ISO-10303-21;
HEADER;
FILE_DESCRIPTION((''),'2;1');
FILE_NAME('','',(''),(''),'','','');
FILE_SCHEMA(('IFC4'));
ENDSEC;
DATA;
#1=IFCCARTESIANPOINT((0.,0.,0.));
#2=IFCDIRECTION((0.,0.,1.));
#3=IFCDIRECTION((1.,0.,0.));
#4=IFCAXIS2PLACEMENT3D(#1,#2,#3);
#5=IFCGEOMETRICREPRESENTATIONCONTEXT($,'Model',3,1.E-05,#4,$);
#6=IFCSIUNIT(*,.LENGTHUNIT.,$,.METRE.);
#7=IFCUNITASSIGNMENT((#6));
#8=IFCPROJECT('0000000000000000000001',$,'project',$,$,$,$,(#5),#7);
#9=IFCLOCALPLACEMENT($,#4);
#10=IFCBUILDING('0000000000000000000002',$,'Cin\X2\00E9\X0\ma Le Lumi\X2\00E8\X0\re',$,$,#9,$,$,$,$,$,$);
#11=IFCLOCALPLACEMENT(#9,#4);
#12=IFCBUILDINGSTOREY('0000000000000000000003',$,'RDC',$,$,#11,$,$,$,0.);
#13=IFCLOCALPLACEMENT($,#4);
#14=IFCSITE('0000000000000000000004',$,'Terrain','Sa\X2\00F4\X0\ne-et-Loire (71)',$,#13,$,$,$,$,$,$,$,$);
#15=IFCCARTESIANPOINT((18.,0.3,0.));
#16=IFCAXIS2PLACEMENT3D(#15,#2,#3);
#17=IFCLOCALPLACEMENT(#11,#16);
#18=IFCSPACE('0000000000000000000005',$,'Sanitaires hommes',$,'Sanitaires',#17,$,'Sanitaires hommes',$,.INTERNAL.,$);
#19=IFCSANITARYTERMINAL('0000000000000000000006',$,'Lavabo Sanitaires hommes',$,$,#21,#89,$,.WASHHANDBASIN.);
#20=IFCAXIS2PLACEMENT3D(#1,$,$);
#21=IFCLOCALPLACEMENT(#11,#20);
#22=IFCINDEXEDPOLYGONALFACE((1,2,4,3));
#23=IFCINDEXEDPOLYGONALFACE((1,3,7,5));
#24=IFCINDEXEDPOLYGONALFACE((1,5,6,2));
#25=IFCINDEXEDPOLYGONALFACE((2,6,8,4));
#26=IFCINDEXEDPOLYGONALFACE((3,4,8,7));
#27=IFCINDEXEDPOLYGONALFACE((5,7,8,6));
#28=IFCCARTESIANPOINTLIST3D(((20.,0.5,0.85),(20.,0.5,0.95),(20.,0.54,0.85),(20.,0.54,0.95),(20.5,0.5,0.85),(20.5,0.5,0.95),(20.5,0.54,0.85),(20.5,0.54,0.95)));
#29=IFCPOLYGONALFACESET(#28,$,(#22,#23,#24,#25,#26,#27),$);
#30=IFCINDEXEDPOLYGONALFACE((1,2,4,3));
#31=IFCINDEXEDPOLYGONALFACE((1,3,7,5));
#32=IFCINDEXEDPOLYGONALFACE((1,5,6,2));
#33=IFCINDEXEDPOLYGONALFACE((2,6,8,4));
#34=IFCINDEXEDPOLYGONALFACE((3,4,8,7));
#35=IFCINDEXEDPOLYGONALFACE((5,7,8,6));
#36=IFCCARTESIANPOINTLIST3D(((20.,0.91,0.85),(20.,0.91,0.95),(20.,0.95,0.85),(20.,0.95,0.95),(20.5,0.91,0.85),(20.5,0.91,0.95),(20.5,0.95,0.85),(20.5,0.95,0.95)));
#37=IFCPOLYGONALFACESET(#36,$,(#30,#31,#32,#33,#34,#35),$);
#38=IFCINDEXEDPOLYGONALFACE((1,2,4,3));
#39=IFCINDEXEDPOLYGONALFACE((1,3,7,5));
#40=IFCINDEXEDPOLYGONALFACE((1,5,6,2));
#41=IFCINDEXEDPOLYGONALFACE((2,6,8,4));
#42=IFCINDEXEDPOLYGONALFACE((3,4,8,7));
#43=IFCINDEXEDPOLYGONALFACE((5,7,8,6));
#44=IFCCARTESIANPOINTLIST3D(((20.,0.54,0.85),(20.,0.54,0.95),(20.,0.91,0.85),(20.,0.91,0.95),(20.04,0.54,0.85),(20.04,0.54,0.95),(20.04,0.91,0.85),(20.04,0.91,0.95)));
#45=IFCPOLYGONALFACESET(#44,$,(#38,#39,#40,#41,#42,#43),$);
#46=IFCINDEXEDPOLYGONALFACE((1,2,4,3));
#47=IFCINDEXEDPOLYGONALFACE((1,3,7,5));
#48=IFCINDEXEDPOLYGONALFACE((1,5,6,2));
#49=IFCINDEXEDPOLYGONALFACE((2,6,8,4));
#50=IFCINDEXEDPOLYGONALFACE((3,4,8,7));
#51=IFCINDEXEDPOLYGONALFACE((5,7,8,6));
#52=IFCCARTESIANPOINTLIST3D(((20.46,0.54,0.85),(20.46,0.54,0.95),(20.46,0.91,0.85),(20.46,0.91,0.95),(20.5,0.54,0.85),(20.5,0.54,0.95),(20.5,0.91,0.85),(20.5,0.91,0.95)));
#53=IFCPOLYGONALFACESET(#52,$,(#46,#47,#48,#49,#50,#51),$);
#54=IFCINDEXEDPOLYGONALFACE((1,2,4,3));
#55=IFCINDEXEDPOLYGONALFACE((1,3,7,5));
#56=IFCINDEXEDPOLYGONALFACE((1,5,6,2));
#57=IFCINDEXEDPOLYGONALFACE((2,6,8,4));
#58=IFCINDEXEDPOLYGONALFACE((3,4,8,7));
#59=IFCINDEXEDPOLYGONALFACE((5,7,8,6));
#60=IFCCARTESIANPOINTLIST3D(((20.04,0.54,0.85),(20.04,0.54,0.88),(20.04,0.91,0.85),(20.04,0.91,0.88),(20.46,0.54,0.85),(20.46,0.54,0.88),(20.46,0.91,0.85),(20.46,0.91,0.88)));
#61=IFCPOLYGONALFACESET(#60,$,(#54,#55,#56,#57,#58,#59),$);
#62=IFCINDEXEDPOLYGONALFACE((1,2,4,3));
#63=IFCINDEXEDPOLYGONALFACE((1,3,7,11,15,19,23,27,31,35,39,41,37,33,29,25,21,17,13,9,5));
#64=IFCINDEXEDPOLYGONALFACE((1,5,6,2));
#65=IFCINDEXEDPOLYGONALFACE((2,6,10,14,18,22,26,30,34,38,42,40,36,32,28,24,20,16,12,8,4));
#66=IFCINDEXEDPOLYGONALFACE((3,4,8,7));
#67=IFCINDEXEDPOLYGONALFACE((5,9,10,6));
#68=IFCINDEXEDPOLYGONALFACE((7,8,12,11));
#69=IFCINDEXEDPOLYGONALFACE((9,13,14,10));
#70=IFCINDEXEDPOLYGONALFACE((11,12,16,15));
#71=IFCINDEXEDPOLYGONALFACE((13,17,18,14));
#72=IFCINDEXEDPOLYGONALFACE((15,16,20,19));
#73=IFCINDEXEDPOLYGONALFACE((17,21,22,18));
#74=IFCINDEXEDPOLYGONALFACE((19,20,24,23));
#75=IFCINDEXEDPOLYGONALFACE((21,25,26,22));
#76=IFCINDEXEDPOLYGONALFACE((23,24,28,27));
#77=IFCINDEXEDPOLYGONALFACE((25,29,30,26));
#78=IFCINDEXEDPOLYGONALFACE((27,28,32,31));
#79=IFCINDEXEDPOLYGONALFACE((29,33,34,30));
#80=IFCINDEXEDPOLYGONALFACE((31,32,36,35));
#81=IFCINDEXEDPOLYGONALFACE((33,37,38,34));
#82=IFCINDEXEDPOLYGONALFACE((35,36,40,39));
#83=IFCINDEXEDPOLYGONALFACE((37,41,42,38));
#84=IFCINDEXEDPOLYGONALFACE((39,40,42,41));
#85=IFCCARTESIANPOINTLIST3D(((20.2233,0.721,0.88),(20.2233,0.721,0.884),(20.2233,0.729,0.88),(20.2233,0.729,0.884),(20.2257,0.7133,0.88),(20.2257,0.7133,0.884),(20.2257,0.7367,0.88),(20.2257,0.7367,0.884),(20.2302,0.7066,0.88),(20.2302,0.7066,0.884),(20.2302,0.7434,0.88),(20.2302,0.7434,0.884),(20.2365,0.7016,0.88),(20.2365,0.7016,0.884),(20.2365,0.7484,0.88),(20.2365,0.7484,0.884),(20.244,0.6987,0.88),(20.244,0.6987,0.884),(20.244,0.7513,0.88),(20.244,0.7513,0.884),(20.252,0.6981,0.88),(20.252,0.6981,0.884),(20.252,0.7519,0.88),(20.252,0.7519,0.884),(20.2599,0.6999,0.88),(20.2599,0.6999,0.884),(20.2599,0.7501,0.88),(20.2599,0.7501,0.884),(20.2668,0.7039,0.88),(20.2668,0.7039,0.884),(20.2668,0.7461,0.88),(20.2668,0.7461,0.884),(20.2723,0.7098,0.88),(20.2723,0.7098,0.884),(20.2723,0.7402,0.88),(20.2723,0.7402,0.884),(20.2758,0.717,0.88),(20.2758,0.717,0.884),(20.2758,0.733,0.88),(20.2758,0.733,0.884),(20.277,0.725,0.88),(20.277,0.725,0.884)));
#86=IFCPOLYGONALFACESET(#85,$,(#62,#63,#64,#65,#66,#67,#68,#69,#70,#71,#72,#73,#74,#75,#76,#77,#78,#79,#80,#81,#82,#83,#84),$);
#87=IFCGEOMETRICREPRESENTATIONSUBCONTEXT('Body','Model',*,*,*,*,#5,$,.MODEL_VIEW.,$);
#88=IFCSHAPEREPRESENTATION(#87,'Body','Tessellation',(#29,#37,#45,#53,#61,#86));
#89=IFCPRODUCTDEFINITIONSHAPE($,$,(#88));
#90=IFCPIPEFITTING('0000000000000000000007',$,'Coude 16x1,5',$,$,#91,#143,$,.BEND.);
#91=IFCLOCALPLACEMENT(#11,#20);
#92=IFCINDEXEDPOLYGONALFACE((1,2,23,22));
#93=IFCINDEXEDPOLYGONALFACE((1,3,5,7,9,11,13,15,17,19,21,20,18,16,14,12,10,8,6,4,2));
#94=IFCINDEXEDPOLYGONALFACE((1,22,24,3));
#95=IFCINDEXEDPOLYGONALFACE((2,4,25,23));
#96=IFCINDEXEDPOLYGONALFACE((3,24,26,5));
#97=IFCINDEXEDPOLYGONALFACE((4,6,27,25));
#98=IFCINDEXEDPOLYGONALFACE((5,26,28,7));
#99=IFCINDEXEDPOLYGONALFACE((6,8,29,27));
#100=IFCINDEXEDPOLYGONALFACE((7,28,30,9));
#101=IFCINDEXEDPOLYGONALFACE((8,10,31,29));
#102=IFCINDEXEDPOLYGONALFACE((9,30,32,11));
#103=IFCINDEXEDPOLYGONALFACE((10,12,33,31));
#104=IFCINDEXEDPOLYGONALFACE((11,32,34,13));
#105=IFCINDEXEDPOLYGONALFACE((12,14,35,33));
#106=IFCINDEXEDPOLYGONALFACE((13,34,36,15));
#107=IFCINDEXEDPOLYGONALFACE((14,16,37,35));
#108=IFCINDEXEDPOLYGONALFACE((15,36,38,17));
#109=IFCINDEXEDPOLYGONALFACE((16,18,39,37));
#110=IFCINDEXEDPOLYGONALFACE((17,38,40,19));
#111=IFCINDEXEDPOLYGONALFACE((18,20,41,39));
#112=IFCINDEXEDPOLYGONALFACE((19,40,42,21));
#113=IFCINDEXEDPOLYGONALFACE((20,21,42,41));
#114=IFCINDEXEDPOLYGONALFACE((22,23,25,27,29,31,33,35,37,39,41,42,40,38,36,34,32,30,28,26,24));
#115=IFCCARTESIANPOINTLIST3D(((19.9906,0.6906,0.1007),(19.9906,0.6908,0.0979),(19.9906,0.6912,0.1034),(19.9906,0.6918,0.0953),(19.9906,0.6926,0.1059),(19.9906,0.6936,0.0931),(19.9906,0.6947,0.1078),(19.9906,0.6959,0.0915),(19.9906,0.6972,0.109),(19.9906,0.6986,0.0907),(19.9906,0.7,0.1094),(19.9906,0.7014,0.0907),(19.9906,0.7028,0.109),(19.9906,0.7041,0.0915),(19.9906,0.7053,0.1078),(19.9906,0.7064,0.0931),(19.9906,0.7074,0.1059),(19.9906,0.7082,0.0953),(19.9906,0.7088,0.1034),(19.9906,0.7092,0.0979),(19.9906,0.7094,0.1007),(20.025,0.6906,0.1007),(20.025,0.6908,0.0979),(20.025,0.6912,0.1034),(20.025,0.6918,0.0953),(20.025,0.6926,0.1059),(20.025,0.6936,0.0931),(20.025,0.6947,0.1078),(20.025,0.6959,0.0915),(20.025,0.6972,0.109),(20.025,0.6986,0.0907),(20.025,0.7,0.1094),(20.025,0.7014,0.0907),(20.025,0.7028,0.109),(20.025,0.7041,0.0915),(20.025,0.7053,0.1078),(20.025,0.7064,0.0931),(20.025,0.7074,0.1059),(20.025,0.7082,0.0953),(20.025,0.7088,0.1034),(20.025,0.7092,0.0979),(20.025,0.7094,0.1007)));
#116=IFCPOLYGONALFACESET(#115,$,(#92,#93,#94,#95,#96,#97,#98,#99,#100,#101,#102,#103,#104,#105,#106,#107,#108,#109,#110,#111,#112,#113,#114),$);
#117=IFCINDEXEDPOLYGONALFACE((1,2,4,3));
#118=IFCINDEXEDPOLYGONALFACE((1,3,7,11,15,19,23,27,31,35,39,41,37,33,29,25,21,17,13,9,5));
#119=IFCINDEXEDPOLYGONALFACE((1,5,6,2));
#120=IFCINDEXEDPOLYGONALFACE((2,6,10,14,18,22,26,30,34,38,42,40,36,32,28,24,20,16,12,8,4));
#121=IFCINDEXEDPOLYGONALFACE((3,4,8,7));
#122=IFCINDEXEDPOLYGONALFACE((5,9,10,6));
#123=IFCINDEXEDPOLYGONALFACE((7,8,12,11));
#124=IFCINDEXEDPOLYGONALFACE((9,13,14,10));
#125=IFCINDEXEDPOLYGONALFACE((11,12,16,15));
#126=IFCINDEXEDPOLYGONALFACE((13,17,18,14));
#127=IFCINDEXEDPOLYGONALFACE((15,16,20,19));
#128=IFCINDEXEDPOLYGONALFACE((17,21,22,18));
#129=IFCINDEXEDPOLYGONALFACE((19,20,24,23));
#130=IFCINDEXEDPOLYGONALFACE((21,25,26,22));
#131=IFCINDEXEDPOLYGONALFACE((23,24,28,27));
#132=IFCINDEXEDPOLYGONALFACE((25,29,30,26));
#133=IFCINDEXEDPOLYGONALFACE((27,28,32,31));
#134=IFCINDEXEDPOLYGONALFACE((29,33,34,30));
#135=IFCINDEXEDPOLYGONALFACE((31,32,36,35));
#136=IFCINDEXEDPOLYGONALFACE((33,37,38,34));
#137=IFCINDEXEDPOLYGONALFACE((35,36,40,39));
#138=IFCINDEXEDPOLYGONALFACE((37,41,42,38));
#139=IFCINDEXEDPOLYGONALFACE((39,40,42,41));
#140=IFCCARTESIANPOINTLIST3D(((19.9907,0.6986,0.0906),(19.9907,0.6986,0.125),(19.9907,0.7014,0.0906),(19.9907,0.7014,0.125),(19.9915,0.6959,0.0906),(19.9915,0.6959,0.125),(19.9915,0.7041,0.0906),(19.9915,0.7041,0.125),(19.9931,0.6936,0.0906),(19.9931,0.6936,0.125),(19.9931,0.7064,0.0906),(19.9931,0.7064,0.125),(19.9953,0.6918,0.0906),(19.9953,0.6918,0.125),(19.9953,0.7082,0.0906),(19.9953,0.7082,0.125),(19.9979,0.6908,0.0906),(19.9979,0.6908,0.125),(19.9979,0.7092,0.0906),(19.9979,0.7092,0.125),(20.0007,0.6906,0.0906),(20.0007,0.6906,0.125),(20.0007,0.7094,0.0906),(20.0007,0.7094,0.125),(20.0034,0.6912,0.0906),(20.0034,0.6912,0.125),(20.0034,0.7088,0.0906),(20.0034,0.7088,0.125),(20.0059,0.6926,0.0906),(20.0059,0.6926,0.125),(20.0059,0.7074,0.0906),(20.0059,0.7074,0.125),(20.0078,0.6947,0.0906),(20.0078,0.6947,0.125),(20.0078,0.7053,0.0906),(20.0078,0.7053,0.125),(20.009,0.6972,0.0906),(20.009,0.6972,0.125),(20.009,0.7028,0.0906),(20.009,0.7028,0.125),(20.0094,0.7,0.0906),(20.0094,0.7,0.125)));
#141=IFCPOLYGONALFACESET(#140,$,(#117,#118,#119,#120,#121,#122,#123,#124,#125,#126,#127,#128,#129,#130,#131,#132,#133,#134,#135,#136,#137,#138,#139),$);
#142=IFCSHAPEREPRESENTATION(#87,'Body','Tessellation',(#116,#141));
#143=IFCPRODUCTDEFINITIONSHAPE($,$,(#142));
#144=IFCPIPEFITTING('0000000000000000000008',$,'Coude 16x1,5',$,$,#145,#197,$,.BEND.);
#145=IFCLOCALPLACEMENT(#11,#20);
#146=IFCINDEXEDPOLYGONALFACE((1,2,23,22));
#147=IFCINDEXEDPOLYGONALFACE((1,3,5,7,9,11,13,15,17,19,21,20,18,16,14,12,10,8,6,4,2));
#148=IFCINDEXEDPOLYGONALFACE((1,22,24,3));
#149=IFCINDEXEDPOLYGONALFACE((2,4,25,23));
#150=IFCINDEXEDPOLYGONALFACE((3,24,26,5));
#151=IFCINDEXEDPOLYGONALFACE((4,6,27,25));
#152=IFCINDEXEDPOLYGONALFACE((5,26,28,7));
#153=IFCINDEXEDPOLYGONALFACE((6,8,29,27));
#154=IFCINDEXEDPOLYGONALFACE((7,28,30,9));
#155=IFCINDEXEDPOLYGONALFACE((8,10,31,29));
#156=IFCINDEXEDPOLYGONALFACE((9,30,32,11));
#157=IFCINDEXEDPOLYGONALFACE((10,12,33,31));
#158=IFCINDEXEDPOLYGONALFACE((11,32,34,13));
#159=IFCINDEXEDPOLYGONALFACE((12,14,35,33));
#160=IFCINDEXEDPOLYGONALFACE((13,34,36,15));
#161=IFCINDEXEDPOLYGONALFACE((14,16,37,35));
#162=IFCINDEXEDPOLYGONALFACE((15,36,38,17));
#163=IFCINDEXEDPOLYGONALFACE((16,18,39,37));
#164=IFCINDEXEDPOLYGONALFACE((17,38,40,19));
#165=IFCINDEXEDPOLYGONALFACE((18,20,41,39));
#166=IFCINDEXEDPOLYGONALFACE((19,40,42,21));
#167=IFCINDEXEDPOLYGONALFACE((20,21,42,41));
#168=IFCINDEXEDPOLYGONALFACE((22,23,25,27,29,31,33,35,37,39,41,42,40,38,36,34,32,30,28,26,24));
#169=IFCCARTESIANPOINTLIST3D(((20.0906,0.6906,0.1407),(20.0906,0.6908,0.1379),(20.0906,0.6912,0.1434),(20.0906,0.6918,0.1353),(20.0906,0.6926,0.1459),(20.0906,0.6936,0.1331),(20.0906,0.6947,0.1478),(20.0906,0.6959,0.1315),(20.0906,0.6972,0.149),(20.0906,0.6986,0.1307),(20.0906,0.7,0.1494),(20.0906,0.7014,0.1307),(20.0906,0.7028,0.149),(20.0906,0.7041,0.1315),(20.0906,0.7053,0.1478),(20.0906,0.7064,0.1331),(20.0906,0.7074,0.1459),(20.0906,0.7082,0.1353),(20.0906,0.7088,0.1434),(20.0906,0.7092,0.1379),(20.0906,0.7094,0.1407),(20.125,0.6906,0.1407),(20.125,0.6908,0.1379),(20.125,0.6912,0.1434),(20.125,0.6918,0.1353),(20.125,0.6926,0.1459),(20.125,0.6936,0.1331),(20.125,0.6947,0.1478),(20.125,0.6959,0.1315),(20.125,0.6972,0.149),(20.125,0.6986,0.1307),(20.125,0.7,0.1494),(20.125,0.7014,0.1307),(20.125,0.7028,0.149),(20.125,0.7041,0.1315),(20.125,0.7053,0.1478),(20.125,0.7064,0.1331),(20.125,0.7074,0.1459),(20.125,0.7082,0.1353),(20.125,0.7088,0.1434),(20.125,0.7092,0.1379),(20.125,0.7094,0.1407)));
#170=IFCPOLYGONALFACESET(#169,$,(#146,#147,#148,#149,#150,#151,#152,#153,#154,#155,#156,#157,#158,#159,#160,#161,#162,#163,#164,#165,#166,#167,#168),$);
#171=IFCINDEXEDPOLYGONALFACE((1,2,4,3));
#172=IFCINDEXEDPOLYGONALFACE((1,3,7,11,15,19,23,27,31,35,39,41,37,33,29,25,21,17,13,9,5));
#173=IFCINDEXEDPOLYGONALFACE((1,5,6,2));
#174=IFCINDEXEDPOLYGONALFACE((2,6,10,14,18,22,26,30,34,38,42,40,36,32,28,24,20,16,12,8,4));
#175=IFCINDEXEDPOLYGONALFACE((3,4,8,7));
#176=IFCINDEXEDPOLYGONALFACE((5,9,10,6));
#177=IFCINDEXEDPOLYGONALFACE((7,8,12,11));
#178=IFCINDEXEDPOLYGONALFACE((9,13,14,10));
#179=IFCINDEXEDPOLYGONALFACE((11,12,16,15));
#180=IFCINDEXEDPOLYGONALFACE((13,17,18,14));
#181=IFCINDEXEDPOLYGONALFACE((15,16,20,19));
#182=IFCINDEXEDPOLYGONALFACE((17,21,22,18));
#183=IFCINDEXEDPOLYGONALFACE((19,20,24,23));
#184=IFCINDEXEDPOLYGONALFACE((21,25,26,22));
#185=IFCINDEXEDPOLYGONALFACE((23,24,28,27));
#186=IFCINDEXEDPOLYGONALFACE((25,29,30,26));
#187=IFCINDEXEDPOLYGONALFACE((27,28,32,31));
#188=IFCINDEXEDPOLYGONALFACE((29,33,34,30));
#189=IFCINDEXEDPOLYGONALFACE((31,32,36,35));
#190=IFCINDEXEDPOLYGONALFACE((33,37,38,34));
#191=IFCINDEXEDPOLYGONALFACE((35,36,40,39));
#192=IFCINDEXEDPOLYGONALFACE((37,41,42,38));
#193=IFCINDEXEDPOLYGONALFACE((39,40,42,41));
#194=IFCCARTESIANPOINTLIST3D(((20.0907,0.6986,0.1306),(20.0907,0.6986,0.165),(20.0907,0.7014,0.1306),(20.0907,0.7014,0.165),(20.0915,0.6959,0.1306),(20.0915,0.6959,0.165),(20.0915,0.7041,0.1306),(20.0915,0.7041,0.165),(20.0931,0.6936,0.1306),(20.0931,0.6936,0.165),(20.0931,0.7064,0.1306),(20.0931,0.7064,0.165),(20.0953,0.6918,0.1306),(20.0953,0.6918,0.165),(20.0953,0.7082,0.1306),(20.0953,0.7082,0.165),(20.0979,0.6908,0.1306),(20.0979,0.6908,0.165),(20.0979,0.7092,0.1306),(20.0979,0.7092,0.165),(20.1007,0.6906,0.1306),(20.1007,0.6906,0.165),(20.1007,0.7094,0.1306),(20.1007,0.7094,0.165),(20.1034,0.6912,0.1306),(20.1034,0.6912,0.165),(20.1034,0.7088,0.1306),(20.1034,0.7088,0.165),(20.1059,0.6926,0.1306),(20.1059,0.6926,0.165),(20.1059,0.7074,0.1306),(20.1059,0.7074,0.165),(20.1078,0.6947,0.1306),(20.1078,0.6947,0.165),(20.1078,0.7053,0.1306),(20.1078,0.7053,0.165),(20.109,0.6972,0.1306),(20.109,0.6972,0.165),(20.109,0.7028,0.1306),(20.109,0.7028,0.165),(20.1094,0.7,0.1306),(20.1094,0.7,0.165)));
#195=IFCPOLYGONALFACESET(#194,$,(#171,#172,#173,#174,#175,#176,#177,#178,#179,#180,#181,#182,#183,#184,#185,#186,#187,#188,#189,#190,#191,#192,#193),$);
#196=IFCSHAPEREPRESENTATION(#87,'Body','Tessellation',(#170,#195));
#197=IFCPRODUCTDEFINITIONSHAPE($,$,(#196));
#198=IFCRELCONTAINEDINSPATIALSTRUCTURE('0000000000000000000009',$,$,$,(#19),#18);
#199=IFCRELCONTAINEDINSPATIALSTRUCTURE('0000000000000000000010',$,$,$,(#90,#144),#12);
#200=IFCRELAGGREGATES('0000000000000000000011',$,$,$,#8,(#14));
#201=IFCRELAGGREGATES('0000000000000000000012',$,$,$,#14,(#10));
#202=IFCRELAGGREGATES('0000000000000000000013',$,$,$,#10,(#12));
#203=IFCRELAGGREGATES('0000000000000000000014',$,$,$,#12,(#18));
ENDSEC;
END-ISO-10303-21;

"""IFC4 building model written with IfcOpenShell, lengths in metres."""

from ifc_helpers import new_model, si_unit, frame, frame_2d, origin_with_axes, place, context, subcontext, project, spatial, rectangle, circle, extrude, element, save


model = new_model("IFC4")

# Units and contexts
model_context = context("Model", 3, precision=1e-05, world=origin_with_axes())
body_context = subcontext(model_context, "Body", "Model", "MODEL_VIEW")
ifc_project = project(units=[si_unit("LENGTHUNIT", "METRE")], contexts=[model_context])

# Site, building, storey
site_placement = place(None, origin_with_axes())
site = spatial("IfcSite", under=ifc_project, at=site_placement, Name="Terrain", Description="Saône-et-Loire (71)")
building_placement = place(None, origin_with_axes())
building = spatial("IfcBuilding", under=site, at=building_placement, Name="Cinéma Le Lumière")
storey_placement = place(building_placement, origin_with_axes())
storey = spatial("IfcBuildingStorey", under=building, at=storey_placement, Name="RDC", Elevation=0.0)

# Shared definitions
space_placement = place(storey_placement, frame((18.0, 0.3, 0.0), z_axis=(0.0, 0.0, 1.0), x_axis=(1.0, 0.0, 0.0)))
space = spatial("IfcSpace", under=storey, at=space_placement, Name="Sanitaires hommes", ObjectType="Sanitaires", LongName="Sanitaires hommes", PredefinedType="INTERNAL")

# Sanitary terminal
sanitary_terminal_1_placement = place(space_placement, frame((2.0, 0.2, 0.85), z_axis=(0.0, 0.0, 1.0), x_axis=(1.0, 0.0, 0.0)))
element("IfcSanitaryTerminal", 1, at=sanitary_terminal_1_placement, inside=space, Name="Lavabo Sanitaires hommes", PredefinedType="WASHHANDBASIN", context=body_context, shape_type="SweptSolid", body=[
    extrude(rectangle(XDim=0.5, YDim=0.04, at=frame_2d((0.25, 0.02))), origin_with_axes(), (0.0, 0.0, 1.0), 0.1),
    extrude(rectangle(XDim=0.5, YDim=0.04, at=frame_2d((0.25, 0.02))), frame((0.0, 0.41, 0.0), z_axis=(0.0, 0.0, 1.0), x_axis=(1.0, 0.0, 0.0)), (0.0, 0.0, 1.0), 0.1),
    extrude(rectangle(XDim=0.04, YDim=0.37, at=frame_2d((0.02, 0.185))), frame((0.0, 0.04, 0.0), z_axis=(0.0, 0.0, 1.0), x_axis=(1.0, 0.0, 0.0)), (0.0, 0.0, 1.0), 0.1),
    extrude(rectangle(XDim=0.04, YDim=0.37, at=frame_2d((0.02, 0.185))), frame((0.46, 0.04, 0.0), z_axis=(0.0, 0.0, 1.0), x_axis=(1.0, 0.0, 0.0)), (0.0, 0.0, 1.0), 0.1),
    extrude(rectangle(XDim=0.42, YDim=0.37, at=frame_2d((0.21, 0.185))), frame((0.04, 0.04, 0.0), z_axis=(0.0, 0.0, 1.0), x_axis=(1.0, 0.0, 0.0)), (0.0, 0.0, 1.0), 0.03),
    extrude(circle(Radius=0.027), frame((0.25, 0.225, 0.03), z_axis=(0.0, 0.0, 1.0), x_axis=(1.0, 0.0, 0.0)), (0.0, 0.0, 1.0), 0.004),
])

# Pipe fittings
for number, where, z_axis, x_axis, name in (
    (2, (20.0, 0.7, 0.1), (0.0, 0.0, 1.0), (1.0, 0.0, 0.0), "Coude 16x1,5"),
    (3, (20.1, 0.7, 0.14), (0.0, 0.0, 1.0), (1.0, 0.0, 0.0), "Coude 16x1,5"),
):
    element("IfcPipeFitting", number, at=place(storey_placement, frame(where, z_axis=z_axis, x_axis=x_axis)), inside=storey, Name=name, PredefinedType="BEND", context=body_context, shape_type="SweptSolid", body=[
        extrude(circle(Radius=0.0094), frame((-0.0094, 0.0, 0.0), z_axis=(1.0, 0.0, 0.0), x_axis=(0.0, 0.0, 1.0)), (0.0, 0.0, 1.0), 0.0344),
        extrude(circle(Radius=0.0094), frame((0.0, 0.0, -0.0094), z_axis=(0.0, 0.0, 1.0), x_axis=(1.0, 0.0, 0.0)), (0.0, 0.0, 1.0), 0.0344),
    ])

save(model, "model.ifc")
